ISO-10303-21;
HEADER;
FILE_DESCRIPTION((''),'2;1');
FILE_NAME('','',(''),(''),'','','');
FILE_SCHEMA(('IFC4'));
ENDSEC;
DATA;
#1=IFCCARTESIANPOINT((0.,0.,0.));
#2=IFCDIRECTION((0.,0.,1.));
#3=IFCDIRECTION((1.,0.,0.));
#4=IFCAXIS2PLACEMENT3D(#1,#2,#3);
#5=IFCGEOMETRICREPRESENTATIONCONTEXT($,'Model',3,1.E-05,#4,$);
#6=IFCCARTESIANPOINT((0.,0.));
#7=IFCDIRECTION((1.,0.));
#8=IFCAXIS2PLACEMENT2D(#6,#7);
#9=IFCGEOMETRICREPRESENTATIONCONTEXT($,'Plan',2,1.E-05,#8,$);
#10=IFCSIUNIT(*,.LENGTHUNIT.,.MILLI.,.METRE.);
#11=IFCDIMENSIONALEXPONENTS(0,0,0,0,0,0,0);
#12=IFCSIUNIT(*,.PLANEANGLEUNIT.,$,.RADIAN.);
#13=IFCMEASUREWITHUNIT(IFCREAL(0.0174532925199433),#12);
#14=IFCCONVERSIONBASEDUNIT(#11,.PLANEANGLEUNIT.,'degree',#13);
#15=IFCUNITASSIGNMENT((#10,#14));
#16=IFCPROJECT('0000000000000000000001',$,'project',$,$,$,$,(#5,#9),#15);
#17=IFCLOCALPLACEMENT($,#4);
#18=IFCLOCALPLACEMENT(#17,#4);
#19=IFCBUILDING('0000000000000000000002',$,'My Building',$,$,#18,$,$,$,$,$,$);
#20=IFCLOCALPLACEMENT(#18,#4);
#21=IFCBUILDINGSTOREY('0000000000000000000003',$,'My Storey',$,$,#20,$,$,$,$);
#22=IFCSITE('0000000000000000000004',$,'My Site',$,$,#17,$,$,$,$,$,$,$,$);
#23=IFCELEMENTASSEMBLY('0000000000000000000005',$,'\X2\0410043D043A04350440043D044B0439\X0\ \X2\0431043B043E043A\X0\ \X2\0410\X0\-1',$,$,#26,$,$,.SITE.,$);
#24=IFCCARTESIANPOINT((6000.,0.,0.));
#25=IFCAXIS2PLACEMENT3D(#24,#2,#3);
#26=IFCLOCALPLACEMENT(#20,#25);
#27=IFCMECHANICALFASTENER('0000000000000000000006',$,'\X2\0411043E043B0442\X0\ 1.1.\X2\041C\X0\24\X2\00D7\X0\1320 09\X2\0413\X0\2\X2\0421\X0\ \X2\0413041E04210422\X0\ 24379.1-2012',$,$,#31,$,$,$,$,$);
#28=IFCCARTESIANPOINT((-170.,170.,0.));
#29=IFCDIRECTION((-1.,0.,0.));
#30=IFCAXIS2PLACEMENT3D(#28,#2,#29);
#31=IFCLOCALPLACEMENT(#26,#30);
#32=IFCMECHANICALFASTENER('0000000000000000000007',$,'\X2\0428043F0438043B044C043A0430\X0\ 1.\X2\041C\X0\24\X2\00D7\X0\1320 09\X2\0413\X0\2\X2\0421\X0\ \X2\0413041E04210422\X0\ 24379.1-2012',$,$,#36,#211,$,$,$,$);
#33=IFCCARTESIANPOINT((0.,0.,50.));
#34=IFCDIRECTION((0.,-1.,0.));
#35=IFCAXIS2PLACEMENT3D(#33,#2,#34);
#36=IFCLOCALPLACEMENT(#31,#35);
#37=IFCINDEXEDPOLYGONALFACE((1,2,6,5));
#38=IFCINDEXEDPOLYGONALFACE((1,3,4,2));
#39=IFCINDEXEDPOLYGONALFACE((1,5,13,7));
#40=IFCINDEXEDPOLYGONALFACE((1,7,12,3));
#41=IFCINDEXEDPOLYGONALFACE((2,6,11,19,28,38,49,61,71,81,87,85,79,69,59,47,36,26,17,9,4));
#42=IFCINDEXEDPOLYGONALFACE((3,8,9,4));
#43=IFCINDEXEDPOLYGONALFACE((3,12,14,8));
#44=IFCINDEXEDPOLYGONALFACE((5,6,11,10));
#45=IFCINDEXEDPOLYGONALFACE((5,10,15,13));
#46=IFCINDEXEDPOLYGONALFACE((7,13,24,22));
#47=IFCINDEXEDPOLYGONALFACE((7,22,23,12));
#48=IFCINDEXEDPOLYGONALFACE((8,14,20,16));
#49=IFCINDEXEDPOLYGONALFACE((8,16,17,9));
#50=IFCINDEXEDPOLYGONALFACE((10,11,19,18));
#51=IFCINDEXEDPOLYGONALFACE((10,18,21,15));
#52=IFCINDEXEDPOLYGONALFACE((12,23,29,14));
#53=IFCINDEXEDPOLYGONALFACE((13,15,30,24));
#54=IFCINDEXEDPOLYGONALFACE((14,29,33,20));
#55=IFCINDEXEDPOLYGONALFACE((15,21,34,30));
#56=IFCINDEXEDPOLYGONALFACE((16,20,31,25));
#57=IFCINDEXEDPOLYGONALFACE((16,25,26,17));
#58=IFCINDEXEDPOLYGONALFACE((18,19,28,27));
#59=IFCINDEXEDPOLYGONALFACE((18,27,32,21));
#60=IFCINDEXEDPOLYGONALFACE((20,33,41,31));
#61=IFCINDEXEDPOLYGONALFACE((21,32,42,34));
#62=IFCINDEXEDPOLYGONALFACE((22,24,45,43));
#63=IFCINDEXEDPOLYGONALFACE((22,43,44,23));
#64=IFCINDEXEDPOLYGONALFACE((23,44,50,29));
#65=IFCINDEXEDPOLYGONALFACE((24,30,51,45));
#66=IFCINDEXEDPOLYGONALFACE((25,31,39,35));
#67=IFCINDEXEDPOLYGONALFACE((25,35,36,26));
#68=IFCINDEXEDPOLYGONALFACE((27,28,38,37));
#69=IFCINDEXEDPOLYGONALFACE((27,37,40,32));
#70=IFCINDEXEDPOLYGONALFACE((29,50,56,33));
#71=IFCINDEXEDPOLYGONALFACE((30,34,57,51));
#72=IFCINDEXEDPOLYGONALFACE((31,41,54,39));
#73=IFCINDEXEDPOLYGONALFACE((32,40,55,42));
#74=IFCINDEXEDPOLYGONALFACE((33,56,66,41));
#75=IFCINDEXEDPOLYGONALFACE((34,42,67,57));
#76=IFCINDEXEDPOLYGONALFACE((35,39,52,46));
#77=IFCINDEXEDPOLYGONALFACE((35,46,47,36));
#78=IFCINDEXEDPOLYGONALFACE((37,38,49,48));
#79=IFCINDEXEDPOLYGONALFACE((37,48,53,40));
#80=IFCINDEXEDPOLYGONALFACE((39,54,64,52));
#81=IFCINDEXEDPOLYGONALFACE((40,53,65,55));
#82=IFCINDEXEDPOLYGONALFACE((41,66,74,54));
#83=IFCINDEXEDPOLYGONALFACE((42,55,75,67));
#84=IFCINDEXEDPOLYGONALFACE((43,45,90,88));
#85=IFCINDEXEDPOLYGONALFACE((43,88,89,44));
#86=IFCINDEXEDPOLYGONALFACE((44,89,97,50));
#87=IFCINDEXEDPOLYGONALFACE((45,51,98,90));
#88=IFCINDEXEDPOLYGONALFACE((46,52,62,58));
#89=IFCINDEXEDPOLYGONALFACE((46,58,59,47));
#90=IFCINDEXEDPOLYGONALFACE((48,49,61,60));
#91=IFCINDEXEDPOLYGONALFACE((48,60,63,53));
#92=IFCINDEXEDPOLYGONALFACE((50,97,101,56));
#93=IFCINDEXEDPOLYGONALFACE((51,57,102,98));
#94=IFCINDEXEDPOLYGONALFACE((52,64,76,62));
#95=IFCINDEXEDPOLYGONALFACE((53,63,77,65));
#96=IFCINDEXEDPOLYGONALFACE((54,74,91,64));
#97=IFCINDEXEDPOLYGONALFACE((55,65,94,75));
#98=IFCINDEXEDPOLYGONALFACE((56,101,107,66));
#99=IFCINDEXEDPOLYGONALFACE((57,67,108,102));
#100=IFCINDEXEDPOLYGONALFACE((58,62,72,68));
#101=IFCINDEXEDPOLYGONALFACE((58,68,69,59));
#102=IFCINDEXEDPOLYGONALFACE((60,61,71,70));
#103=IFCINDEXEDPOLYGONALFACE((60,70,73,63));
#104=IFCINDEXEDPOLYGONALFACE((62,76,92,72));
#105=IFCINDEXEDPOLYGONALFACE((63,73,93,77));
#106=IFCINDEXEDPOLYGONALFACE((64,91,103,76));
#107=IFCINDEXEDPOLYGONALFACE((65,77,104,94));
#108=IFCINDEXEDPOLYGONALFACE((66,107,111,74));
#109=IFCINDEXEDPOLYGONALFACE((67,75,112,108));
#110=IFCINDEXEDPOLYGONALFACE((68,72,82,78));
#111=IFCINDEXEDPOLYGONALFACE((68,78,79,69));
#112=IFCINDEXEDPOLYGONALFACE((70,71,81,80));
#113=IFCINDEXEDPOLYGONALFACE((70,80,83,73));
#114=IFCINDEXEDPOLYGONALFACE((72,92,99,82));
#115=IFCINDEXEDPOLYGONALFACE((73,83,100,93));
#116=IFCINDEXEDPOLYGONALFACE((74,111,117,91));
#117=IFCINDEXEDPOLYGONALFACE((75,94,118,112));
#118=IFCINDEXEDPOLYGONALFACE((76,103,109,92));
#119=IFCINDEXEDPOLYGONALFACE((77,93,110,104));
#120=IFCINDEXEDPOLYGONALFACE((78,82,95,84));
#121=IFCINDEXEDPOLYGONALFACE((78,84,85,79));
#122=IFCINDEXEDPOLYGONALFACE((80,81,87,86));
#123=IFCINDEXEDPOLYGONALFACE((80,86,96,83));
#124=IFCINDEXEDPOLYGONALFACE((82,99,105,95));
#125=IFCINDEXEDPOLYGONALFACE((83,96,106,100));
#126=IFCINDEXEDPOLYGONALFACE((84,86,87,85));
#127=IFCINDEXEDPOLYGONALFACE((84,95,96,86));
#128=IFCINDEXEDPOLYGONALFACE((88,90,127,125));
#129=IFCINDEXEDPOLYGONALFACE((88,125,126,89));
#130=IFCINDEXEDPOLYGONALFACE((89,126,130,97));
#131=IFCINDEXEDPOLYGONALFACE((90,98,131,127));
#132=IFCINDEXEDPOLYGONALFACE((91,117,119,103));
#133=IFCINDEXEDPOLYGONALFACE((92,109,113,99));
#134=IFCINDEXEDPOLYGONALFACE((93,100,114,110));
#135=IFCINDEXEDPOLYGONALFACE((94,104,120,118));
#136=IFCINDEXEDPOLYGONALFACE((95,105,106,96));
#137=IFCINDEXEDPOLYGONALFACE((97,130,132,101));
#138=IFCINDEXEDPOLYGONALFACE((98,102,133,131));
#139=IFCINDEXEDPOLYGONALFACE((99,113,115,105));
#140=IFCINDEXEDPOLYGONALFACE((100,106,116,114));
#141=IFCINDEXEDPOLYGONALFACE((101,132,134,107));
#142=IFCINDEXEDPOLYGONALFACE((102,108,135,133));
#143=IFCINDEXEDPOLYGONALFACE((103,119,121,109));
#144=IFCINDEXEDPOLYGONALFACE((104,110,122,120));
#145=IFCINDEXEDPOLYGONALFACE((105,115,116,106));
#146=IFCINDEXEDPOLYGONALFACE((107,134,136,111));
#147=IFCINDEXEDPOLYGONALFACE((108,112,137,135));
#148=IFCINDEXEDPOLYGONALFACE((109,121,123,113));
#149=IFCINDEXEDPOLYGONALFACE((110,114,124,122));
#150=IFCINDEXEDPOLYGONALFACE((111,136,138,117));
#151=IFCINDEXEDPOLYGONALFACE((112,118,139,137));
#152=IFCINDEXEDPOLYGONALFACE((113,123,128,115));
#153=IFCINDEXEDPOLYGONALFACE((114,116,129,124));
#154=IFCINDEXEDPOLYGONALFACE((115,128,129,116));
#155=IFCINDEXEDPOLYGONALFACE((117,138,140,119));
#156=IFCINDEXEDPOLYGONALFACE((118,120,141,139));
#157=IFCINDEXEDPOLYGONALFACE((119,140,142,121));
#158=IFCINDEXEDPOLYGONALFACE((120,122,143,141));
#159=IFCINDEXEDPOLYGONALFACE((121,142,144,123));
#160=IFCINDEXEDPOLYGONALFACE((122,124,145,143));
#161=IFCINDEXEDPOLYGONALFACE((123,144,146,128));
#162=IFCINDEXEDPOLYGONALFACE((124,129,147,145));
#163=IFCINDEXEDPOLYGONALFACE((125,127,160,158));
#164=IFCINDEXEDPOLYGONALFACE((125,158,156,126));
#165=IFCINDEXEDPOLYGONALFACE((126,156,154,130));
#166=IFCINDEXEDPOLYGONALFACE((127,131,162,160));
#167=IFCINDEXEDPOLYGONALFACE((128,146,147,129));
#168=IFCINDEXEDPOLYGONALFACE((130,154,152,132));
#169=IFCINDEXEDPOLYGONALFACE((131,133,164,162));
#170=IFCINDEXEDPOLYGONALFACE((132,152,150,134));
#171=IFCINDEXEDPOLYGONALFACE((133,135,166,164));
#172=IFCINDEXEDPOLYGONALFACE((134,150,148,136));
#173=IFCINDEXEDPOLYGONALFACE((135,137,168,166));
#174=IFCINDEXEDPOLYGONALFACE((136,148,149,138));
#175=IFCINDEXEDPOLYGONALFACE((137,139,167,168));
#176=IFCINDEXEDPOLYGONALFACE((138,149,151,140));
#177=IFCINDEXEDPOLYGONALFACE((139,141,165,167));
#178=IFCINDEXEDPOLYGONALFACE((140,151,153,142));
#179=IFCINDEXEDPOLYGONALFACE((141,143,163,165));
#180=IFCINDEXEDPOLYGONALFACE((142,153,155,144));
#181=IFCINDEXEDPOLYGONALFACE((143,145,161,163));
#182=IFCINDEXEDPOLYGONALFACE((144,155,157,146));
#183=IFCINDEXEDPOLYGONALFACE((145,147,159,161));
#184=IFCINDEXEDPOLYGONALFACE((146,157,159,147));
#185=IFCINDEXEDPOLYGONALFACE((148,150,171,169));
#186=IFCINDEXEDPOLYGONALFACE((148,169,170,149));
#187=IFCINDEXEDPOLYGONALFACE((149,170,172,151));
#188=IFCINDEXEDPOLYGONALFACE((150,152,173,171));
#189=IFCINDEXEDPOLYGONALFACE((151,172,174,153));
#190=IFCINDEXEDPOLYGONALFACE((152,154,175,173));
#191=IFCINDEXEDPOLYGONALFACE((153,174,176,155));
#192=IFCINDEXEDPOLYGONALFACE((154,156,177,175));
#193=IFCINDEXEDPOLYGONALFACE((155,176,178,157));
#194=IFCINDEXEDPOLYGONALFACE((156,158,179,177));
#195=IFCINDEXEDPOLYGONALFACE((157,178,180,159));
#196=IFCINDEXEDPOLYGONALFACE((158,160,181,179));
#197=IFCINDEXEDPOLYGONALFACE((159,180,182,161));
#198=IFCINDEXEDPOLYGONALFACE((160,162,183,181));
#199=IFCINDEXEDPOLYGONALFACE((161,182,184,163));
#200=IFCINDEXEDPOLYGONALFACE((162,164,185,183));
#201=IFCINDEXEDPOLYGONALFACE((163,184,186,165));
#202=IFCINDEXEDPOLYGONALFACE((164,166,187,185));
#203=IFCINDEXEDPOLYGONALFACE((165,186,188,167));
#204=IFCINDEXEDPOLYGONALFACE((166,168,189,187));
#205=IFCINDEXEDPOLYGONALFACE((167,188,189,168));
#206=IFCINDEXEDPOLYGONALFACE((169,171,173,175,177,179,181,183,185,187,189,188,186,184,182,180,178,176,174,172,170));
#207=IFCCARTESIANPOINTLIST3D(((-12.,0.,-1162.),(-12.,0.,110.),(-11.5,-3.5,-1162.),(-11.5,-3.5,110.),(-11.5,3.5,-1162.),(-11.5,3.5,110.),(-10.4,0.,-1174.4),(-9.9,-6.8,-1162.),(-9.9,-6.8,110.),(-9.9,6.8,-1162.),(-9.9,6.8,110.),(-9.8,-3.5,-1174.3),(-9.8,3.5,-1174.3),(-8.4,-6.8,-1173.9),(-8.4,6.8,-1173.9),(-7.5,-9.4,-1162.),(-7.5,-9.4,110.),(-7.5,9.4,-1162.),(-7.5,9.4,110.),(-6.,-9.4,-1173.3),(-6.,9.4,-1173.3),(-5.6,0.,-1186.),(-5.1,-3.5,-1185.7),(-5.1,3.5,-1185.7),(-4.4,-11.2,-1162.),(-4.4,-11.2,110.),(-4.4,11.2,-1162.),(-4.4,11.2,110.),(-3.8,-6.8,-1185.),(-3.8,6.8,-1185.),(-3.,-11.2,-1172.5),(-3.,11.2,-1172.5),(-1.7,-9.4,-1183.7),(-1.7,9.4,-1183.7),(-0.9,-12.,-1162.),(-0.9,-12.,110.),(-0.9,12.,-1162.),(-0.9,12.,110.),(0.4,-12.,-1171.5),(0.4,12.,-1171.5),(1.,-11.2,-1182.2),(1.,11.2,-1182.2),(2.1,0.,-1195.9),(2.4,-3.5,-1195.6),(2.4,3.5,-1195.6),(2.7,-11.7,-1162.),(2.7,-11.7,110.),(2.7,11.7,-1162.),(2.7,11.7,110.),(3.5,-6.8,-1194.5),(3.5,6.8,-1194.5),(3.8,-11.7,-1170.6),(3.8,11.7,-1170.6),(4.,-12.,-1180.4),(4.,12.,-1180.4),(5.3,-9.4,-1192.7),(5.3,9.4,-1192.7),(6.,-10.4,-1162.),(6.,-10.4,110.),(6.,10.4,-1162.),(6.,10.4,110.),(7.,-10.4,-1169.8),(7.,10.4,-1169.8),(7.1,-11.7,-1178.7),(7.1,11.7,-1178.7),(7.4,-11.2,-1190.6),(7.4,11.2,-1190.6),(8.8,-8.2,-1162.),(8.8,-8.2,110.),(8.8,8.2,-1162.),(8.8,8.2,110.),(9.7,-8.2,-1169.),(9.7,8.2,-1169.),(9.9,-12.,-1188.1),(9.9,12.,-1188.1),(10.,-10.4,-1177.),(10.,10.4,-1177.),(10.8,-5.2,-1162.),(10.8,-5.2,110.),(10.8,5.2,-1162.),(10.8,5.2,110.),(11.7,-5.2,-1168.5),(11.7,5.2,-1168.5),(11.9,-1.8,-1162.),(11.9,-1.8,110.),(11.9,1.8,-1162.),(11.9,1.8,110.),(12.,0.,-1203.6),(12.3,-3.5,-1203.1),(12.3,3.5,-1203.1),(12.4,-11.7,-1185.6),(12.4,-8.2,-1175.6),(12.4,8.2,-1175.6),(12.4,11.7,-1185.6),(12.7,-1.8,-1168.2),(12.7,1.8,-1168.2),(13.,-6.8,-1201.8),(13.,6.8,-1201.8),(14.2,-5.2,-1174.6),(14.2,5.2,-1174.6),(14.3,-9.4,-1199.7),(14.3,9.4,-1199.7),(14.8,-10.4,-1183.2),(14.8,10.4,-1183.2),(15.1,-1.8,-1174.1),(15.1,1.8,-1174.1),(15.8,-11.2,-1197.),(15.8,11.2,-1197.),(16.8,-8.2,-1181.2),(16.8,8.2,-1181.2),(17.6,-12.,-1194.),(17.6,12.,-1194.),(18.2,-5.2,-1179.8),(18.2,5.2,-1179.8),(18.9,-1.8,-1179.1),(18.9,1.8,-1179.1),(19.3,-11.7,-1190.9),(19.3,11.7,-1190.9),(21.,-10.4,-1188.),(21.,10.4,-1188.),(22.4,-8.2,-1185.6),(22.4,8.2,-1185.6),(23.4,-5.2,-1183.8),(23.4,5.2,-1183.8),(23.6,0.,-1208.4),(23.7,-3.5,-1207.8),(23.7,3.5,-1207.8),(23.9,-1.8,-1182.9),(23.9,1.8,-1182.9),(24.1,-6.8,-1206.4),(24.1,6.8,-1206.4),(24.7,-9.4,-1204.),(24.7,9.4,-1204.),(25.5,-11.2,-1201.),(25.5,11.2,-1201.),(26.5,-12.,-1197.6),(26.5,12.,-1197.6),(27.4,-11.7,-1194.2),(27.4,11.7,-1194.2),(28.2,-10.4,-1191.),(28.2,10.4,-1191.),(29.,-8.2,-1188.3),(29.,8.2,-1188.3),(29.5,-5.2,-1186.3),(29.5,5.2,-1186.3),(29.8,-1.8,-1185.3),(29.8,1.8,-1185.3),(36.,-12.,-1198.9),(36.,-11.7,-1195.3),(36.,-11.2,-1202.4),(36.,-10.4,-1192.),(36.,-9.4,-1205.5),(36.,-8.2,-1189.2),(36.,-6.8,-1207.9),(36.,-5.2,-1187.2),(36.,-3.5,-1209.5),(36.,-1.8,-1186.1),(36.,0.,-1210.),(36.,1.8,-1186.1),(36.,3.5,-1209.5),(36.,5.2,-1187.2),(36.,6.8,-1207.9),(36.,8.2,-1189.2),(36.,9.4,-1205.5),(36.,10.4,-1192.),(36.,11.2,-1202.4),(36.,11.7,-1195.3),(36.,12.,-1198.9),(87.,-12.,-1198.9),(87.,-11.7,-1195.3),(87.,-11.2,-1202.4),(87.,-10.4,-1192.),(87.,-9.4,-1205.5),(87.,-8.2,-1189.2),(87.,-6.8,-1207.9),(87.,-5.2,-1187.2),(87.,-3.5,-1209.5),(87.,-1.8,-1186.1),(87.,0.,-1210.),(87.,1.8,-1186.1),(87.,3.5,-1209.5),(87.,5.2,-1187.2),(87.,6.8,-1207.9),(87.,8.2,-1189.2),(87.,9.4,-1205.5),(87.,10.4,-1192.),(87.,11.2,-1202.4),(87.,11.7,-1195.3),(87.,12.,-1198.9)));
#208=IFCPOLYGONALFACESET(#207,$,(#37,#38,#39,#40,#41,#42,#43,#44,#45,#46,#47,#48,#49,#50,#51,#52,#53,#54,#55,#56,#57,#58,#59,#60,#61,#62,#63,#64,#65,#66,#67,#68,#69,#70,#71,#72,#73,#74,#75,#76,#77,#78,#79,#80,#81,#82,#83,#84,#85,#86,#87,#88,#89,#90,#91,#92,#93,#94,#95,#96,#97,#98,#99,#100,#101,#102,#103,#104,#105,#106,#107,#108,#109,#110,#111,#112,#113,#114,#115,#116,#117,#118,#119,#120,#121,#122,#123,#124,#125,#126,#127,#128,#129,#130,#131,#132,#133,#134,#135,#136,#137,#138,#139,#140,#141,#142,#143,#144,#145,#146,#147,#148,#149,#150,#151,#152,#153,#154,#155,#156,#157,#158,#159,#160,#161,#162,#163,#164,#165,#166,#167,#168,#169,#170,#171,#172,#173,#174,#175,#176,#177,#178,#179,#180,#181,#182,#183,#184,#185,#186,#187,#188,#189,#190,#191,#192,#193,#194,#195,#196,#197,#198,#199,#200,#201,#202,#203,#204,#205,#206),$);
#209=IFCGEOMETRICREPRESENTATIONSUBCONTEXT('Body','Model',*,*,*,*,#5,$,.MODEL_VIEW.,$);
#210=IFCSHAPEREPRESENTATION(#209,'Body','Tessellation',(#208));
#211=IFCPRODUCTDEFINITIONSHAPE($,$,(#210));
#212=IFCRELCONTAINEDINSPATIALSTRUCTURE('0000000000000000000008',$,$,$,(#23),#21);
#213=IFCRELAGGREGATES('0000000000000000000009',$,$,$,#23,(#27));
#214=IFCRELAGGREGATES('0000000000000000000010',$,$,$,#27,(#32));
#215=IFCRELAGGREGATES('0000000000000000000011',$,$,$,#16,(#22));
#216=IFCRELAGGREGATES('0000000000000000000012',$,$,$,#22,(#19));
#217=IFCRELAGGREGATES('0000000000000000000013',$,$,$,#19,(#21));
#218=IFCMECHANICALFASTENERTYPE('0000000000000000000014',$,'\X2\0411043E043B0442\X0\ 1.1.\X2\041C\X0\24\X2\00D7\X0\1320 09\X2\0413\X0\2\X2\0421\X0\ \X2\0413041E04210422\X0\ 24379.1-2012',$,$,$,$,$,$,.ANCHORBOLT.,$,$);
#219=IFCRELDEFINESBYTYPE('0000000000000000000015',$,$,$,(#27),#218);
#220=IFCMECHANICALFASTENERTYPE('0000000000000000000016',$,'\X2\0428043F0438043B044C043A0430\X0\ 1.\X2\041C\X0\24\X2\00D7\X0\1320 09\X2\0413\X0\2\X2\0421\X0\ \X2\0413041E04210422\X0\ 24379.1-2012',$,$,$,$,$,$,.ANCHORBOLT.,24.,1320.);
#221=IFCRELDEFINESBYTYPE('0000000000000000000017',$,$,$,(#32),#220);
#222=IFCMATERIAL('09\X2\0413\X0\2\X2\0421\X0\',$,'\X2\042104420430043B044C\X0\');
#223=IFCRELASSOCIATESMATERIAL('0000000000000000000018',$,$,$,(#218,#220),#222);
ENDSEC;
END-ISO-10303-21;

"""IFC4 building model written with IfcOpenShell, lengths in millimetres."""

from ifc_helpers import new_model, entity, si_unit, converted_unit, frame, origin_with_axes, origin_2d_with_axis, place, context, subcontext, project, spatial, source, transform, mapped, material, type_object, type_shapes, element, aggregate, save


model = new_model("IFC4")

# Units and contexts
model_context = context("Model", 3, precision=1e-05, world=origin_with_axes())
plan_context = context("Plan", 2, precision=1e-05, world=origin_2d_with_axis())
body_context = subcontext(model_context, "Body", "Model", "MODEL_VIEW")
ifc_project = project(units=[si_unit("LENGTHUNIT", "METRE", prefix="MILLI"), converted_unit("PLANEANGLEUNIT", "degree", entity("IfcReal", 0.0174532925199433), si_unit("PLANEANGLEUNIT", "RADIAN"), dimensions=[0, 0, 0, 0, 0, 0, 0])], contexts=[model_context, plan_context])

# Site, building, storey
site_placement = place(None, origin_with_axes())
site = spatial("IfcSite", under=ifc_project, at=site_placement, Name="My Site")
building_placement = place(site_placement, origin_with_axes())
building = spatial("IfcBuilding", under=site, at=building_placement, Name="My Building")
storey_placement = place(building_placement, origin_with_axes())
storey = spatial("IfcBuildingStorey", under=building, at=storey_placement, Name="My Storey")

# Element assembly, mechanical fasteners
assembly_1_placement = place(storey_placement, frame((6000.0, 0.0, 0.0), z_axis=(0.0, 0.0, 1.0), x_axis=(1.0, 0.0, 0.0)))
assembly_1 = element("IfcElementAssembly", 1, at=assembly_1_placement, inside=storey, Name="Анкерный блок А-1", AssemblyPlace="SITE")
ifc_material_1 = material(Name="09Г2С", Category="Сталь")
mechanical_fastener_type_1 = type_object("IfcMechanicalFastenerType", Name="Болт 1.1.М24×1320 09Г2С ГОСТ 24379.1-2012", PredefinedType="ANCHORBOLT", material=ifc_material_1)
mechanical_fastener_type_2 = type_object("IfcMechanicalFastenerType", Name="Шпилька 1.М24×1320 09Г2С ГОСТ 24379.1-2012", NominalDiameter=24.0, NominalLength=1320.0, PredefinedType="ANCHORBOLT", material=ifc_material_1)
shared_shape_1 = source(frame((0.0, 0.0, 110.0), z_axis=(0.0, 0.0, 1.0), x_axis=(1.0, 0.0, 0.0)), body_context, "Body", "AdvancedSweptSolid", [
    entity("IfcSweptDiskSolid", entity("IfcIndexedPolyCurve", entity("IfcCartesianPointList3D", [[0.0, 0.0, 0.0], [0.0, 0.0, -1272.0], [10.5, 0.0, -1297.5], [36.0, 0.0, -1308.0], [87.0, 0.0, -1308.0]]), [entity("IfcLineIndex", [1, 2]), entity("IfcArcIndex", [2, 3, 4]), entity("IfcLineIndex", [4, 5])]), 12.0),
])
type_shapes(mechanical_fastener_type_2, [shared_shape_1])
mechanical_fastener_1_placement = place(assembly_1_placement, frame((-170.0, 170.0, 0.0), z_axis=(0.0, 0.0, 1.0), x_axis=(-1.0, 0.0, 0.0)))
mechanical_fastener_1 = element("IfcMechanicalFastener", 2, at=mechanical_fastener_1_placement, type_object=mechanical_fastener_type_1, Name="Болт 1.1.М24×1320 09Г2С ГОСТ 24379.1-2012")
mechanical_fastener_2_placement = place(mechanical_fastener_1_placement, frame((0.0, 0.0, 50.0), z_axis=(0.0, 0.0, 1.0), x_axis=(0.0, -1.0, 0.0)))
mechanical_fastener_2 = element("IfcMechanicalFastener", 3, at=mechanical_fastener_2_placement, type_object=mechanical_fastener_type_2, Name="Шпилька 1.М24×1320 09Г2С ГОСТ 24379.1-2012", context=body_context, shape_type="MappedRepresentation", body=[
    mapped(shared_shape_1, transform((0.0, 0.0, 0.0), x_axis=(1.0, 0.0, 0.0), y_axis=(0.0, 1.0, 0.0), z_axis=(0.0, 0.0, 1.0), scale=1.0)),
])
aggregate(assembly_1, [mechanical_fastener_1])

aggregate(mechanical_fastener_1, [mechanical_fastener_2])

save(model, "model.ifc")
